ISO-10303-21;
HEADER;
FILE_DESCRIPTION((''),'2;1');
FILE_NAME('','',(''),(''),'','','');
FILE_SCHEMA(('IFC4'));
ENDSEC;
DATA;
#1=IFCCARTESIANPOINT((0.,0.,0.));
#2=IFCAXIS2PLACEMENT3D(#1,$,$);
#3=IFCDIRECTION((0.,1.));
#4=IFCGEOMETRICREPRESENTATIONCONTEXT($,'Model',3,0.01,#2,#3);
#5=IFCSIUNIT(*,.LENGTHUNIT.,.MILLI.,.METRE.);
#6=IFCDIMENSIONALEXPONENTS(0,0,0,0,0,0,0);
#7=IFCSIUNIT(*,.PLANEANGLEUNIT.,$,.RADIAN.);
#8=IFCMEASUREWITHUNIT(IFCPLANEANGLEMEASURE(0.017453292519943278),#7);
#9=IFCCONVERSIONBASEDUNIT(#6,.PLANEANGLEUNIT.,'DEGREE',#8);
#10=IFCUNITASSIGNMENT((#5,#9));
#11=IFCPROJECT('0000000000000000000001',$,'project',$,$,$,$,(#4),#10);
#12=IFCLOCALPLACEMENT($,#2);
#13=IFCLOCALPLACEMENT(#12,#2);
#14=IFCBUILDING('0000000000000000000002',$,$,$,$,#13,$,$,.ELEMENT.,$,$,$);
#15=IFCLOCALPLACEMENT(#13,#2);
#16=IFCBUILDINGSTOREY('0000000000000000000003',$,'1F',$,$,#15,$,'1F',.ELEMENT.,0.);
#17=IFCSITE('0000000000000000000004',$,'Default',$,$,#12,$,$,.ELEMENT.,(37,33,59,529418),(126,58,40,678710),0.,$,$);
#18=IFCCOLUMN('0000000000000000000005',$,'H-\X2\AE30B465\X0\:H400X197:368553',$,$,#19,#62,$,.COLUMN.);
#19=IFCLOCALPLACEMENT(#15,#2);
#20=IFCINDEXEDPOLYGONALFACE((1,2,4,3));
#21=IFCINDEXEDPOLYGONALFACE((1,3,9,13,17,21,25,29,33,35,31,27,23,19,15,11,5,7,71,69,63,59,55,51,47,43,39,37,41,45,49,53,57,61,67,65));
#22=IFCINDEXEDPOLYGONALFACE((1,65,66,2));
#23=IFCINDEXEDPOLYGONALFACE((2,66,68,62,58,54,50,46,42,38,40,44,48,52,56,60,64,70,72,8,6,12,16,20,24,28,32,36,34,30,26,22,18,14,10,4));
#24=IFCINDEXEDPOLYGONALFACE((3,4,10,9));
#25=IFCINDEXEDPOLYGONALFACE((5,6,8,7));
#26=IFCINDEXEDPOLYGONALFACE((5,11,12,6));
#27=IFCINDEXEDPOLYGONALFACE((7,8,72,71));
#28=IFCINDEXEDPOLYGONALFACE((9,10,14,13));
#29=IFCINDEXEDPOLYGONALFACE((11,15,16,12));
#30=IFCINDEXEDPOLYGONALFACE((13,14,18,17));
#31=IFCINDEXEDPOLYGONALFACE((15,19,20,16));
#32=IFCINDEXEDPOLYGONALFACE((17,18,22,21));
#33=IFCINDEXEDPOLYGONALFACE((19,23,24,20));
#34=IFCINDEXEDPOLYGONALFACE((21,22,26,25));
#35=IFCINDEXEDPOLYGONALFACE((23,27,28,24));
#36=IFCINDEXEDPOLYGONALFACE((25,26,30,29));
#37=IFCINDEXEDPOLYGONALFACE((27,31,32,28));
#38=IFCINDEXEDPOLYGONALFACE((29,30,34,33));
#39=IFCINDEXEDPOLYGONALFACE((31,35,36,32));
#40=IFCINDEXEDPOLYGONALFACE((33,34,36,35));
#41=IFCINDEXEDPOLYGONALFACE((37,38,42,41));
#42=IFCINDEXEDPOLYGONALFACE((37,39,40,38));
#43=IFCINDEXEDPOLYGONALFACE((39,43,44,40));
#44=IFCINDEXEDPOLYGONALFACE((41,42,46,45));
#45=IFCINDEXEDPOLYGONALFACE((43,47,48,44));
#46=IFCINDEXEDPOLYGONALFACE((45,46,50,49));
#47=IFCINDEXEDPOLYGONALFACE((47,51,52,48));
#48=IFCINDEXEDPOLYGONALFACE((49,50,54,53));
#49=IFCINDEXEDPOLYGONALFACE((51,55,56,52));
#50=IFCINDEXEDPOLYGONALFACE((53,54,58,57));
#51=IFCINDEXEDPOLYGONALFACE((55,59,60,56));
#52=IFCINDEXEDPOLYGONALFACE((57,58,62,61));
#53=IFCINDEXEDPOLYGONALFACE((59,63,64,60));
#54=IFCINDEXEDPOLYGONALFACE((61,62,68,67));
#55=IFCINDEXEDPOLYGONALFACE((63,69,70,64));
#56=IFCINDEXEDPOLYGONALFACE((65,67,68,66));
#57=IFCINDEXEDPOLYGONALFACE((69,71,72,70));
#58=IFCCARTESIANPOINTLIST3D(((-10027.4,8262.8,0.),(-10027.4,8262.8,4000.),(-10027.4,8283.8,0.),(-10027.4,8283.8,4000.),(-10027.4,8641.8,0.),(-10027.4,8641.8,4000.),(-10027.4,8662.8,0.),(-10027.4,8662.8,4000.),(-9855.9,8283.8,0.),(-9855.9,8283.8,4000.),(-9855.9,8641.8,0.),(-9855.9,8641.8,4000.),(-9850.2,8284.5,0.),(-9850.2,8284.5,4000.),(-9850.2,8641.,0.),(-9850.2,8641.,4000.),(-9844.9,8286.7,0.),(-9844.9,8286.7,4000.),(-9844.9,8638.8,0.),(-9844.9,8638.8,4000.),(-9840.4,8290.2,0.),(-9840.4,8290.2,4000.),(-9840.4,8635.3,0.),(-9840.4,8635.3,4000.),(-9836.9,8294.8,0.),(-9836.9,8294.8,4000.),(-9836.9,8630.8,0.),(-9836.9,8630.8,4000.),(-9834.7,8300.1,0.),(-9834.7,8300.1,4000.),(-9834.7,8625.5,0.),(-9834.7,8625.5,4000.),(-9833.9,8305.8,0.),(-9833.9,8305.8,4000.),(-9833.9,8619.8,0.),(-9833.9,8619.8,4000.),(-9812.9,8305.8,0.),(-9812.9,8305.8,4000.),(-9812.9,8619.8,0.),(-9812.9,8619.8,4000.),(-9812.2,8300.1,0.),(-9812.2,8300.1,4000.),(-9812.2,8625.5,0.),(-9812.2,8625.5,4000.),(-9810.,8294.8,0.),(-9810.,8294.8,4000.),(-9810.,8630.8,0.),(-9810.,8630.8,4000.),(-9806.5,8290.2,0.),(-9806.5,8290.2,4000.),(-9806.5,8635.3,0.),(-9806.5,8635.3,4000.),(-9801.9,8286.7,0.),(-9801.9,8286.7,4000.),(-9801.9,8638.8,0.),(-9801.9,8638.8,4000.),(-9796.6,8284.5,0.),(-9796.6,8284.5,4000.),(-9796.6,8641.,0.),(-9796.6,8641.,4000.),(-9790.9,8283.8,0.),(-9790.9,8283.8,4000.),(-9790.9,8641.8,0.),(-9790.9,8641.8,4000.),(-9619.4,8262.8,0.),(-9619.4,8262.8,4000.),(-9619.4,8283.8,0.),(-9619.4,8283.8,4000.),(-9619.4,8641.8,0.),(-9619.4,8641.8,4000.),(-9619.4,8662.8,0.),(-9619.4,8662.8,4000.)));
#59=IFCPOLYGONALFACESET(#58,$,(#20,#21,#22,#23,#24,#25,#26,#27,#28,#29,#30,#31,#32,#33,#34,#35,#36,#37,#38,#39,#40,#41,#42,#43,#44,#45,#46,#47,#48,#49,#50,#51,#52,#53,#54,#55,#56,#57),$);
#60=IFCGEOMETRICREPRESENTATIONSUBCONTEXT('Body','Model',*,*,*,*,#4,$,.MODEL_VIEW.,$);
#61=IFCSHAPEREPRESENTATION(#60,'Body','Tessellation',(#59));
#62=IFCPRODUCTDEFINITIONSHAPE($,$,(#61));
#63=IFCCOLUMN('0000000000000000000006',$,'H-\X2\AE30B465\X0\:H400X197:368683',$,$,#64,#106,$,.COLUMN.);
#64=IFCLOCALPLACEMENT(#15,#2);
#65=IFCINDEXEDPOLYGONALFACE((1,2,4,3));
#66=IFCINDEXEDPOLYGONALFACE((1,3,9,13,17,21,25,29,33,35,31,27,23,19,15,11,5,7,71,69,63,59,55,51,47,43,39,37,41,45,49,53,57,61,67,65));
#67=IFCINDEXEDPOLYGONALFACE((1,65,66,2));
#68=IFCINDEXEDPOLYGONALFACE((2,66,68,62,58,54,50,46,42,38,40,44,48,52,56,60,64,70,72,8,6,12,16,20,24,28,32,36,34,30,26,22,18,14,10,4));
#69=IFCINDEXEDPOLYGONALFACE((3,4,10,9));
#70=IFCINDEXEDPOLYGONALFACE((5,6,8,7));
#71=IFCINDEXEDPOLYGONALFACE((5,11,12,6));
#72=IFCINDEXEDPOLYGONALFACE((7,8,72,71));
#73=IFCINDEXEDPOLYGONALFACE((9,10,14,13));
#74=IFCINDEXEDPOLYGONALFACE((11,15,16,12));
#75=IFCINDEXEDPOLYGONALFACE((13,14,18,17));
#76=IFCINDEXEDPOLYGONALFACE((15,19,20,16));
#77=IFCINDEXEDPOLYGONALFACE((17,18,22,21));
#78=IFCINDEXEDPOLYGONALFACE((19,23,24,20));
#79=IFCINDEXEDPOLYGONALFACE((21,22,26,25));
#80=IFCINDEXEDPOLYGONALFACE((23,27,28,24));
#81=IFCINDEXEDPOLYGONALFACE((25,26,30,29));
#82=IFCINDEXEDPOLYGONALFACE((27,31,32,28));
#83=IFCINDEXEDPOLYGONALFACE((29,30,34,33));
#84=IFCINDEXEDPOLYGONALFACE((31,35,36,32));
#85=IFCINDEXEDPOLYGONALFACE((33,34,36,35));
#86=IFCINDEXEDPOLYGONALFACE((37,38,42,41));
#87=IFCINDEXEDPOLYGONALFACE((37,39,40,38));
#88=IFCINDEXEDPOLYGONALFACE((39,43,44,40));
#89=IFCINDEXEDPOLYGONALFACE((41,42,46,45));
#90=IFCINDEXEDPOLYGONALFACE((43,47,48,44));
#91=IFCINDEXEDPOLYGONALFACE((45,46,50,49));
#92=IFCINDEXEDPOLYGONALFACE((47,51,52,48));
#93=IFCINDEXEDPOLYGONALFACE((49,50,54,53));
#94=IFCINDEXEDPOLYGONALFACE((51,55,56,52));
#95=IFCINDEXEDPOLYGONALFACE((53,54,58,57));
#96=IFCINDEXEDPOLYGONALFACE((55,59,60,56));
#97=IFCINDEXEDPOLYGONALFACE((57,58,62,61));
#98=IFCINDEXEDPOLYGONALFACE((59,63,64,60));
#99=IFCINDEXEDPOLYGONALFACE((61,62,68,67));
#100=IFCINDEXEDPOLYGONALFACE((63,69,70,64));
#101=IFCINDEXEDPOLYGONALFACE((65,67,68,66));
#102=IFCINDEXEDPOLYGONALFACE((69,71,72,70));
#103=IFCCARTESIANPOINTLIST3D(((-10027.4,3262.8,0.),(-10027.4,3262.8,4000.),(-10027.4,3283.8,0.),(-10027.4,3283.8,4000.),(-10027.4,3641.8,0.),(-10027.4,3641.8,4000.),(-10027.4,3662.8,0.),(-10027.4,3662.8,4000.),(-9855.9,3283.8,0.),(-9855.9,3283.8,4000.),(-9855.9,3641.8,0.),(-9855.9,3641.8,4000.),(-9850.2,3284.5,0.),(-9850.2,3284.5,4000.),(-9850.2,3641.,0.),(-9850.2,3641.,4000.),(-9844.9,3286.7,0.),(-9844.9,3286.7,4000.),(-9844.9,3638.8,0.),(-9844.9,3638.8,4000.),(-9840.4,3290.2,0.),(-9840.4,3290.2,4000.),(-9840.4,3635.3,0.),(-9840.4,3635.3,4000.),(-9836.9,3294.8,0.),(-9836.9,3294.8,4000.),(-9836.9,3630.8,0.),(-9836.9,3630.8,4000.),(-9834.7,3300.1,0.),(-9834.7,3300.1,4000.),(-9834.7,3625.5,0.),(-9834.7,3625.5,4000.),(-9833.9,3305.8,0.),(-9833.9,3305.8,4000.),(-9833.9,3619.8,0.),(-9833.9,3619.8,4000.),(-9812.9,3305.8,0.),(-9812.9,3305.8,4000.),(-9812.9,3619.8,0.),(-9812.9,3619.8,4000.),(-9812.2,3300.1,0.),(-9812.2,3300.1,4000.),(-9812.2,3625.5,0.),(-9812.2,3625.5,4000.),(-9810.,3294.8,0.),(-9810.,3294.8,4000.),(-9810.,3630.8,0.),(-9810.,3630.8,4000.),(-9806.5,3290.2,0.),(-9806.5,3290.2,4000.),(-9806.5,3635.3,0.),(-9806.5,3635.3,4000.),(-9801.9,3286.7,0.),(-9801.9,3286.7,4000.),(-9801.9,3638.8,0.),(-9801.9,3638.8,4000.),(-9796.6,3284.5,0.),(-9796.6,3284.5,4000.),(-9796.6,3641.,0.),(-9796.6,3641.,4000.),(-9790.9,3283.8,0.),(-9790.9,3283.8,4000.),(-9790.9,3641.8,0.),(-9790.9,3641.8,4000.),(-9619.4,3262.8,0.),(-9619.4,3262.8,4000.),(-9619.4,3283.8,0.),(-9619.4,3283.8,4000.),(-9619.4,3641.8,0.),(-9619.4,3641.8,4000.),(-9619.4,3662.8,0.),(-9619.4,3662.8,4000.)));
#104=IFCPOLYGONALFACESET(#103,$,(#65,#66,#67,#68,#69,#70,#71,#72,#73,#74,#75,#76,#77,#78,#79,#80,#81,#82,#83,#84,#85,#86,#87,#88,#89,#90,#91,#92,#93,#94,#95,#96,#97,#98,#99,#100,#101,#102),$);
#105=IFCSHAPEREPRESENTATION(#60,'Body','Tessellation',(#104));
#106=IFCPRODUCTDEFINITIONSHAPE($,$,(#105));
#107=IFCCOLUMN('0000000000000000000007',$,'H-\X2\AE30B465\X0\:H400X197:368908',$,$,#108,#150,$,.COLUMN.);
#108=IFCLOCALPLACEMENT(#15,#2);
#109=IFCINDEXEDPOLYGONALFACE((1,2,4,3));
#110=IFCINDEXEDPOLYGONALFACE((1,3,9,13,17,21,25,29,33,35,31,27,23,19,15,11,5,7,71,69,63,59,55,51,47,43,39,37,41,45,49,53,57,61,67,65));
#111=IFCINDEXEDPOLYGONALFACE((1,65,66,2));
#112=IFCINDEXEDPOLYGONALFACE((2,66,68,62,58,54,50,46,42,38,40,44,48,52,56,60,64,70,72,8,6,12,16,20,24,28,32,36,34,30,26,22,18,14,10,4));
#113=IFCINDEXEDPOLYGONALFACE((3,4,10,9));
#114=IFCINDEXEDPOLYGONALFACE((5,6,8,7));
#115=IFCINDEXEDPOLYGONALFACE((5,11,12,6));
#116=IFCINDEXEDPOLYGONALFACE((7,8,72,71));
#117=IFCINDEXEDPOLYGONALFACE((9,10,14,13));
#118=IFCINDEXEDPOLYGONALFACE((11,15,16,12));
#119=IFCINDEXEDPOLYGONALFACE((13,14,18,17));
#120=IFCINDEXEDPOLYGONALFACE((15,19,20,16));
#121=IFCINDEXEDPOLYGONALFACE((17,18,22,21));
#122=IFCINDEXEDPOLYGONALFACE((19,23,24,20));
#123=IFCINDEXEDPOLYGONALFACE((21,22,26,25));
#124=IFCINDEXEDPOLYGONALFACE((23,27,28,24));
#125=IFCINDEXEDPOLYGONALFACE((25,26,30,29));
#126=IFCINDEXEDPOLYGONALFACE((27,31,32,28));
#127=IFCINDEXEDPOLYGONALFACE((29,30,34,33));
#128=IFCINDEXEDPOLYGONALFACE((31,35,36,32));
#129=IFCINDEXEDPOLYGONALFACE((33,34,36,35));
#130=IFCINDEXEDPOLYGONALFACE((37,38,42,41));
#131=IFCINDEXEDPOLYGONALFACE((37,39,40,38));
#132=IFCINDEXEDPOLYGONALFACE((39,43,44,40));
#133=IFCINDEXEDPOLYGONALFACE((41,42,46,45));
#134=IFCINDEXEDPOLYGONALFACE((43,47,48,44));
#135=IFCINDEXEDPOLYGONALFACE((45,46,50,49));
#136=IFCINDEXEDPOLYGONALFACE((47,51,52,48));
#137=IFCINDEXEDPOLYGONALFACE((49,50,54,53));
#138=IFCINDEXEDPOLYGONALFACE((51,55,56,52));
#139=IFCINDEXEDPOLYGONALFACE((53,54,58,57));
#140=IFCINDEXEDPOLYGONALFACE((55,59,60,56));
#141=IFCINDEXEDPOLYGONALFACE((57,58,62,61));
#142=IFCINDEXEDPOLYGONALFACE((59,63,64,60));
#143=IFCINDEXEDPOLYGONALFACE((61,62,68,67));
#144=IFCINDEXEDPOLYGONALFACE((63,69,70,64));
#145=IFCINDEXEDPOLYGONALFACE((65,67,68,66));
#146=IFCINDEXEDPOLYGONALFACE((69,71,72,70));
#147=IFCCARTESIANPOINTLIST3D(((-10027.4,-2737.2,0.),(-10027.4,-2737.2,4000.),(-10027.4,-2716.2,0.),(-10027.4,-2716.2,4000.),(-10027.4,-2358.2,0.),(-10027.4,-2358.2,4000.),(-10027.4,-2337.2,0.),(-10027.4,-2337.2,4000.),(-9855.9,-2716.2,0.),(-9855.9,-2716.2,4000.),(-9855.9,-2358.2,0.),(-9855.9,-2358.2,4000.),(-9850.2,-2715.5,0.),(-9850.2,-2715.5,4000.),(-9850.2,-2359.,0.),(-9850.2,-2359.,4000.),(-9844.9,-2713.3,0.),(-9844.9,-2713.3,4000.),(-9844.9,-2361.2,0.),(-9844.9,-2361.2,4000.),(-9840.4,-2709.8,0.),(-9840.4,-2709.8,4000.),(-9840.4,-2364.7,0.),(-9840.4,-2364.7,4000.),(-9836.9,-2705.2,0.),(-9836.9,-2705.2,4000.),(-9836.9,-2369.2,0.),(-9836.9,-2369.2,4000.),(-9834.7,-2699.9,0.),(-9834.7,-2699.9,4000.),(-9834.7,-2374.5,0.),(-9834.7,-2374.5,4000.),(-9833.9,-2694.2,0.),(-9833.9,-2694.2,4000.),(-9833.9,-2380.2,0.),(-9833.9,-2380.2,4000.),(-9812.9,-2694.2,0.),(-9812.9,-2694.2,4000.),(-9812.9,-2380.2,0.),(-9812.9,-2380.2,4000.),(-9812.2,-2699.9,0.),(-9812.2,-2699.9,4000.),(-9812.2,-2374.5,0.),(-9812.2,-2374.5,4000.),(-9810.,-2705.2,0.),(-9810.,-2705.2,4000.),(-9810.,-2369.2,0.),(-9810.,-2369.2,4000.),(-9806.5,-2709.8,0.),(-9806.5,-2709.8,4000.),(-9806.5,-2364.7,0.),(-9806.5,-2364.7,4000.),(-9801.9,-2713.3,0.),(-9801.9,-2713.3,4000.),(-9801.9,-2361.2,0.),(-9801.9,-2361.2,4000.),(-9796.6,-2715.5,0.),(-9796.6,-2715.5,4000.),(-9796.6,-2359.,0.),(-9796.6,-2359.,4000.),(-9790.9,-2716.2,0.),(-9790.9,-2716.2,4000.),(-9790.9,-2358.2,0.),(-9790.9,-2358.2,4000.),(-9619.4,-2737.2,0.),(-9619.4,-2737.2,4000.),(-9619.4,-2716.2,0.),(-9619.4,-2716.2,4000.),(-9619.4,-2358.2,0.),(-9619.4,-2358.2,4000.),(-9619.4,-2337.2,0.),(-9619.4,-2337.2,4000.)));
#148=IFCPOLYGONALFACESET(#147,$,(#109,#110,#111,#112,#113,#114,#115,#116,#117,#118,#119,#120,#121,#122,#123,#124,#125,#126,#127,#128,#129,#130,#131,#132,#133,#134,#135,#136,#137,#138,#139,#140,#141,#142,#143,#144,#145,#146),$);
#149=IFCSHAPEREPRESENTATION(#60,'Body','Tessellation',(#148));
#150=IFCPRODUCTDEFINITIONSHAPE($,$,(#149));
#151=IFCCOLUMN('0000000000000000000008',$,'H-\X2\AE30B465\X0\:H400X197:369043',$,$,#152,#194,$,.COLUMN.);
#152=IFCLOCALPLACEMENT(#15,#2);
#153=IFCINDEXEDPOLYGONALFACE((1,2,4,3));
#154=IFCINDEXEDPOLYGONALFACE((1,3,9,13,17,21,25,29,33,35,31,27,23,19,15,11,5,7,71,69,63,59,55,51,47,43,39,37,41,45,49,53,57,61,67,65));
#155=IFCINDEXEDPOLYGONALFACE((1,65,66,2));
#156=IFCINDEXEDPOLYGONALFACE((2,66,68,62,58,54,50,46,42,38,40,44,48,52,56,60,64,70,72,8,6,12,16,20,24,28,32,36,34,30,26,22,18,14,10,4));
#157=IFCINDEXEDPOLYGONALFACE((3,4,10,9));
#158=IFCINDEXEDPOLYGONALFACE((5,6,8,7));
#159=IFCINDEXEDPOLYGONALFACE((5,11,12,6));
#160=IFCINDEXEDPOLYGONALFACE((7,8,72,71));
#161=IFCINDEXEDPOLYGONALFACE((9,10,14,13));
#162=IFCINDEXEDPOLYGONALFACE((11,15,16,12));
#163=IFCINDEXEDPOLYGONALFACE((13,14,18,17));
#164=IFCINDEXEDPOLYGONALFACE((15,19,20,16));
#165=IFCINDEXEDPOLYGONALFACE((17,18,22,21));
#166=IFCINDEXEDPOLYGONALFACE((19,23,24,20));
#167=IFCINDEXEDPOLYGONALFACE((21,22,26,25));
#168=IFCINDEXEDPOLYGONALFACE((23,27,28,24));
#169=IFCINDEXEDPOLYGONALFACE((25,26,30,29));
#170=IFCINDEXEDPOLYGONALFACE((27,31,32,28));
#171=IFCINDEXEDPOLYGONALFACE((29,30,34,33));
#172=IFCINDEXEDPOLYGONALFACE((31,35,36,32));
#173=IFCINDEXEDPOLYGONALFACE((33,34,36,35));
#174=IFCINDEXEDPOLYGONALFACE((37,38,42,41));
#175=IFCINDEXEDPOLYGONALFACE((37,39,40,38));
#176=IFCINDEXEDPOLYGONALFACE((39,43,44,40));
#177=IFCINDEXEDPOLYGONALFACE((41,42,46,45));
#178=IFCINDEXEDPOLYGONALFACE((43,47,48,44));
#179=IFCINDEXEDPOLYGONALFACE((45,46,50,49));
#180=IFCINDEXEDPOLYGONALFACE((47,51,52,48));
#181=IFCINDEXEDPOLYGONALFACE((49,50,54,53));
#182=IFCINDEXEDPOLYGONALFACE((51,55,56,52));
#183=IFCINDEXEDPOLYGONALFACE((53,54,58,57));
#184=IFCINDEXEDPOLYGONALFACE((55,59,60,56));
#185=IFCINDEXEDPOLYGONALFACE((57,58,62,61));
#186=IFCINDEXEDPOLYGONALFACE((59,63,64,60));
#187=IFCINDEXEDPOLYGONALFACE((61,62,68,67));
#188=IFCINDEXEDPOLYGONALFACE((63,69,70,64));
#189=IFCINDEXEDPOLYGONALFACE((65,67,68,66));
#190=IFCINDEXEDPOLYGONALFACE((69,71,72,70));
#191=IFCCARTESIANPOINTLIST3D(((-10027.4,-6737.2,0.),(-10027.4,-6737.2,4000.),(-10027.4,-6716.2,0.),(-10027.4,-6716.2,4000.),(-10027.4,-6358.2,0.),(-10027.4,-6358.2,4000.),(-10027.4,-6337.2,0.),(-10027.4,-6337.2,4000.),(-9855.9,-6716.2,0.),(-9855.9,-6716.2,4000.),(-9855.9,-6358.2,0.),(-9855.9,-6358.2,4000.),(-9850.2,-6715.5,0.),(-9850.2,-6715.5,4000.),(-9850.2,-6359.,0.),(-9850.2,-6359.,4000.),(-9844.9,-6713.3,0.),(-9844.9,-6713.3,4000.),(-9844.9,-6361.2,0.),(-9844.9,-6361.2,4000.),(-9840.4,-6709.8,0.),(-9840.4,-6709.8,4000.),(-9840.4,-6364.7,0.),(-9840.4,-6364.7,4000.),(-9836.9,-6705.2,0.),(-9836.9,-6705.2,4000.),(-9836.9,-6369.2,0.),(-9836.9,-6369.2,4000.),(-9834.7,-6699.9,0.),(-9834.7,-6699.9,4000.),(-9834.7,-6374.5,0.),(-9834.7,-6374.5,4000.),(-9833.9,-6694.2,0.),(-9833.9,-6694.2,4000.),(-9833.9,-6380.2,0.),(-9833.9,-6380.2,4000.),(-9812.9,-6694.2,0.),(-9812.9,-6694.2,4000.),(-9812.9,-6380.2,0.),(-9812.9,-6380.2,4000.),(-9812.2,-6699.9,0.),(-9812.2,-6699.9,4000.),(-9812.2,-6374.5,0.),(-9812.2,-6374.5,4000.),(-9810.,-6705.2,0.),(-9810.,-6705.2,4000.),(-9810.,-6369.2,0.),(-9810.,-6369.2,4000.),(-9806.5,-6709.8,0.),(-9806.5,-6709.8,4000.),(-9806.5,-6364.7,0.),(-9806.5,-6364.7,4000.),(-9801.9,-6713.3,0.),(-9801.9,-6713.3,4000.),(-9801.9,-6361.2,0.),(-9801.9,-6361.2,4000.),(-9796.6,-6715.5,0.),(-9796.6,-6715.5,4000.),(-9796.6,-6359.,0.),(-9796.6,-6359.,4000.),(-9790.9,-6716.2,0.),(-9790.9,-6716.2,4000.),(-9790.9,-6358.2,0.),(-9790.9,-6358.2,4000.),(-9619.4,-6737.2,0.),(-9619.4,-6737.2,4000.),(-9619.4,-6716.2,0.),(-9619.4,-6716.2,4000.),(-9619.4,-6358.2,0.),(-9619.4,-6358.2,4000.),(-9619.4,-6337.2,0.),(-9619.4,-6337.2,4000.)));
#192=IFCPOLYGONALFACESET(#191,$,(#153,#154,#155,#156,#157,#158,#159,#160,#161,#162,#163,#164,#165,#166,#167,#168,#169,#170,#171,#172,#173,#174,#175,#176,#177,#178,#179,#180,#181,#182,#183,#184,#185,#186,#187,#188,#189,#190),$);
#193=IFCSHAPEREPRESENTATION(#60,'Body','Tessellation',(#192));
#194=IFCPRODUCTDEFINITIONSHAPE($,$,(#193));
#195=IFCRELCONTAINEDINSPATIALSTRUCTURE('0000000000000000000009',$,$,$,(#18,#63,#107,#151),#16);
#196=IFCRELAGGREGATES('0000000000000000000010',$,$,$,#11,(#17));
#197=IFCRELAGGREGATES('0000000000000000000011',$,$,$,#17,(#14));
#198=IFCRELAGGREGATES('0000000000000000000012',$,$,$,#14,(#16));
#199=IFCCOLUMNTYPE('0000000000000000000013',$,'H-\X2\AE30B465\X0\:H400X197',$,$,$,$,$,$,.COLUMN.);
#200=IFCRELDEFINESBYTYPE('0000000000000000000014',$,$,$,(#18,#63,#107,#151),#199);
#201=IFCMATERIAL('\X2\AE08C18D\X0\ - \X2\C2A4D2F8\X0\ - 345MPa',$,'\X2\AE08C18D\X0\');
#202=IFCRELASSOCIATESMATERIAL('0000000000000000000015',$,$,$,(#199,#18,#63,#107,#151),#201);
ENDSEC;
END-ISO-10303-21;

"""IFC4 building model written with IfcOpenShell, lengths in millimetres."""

from ifc_helpers import new_model, entity, si_unit, converted_unit, direction, frame, origin, place, context, subcontext, project, spatial, line, arc, indexed_curve, outline, extrude, source, transform, mapped, material, type_object, type_shapes, element, save


model = new_model("IFC4")

# Units and contexts
model_context = context("Model", 3, precision=0.01, world=origin(), true_north=direction((0.0, 1.0)))
body_context = subcontext(model_context, "Body", "Model", "MODEL_VIEW")
ifc_project = project(units=[si_unit("LENGTHUNIT", "METRE", prefix="MILLI"), converted_unit("PLANEANGLEUNIT", "DEGREE", entity("IfcPlaneAngleMeasure", 0.017453292519943278), si_unit("PLANEANGLEUNIT", "RADIAN"), dimensions=[0, 0, 0, 0, 0, 0, 0])], contexts=[model_context])

# Site, building, storey
site_placement = place(None, origin())
site = spatial("IfcSite", under=ifc_project, at=site_placement, Name="Default", CompositionType="ELEMENT", RefLatitude=(37, 33, 59, 529418), RefLongitude=(126, 58, 40, 678710), RefElevation=0.0)
building_placement = place(site_placement, origin())
building = spatial("IfcBuilding", under=site, at=building_placement, CompositionType="ELEMENT")
storey_placement = place(building_placement, origin())
storey = spatial("IfcBuildingStorey", under=building, at=storey_placement, Name="1F", LongName="1F", CompositionType="ELEMENT", Elevation=0.0)

# Columns
ifc_material = material(Name="금속 - 스틸 - 345MPa", Category="금속")
column_type = type_object("IfcColumnType", Name="H-기둥:H400X197", PredefinedType="COLUMN", material=ifc_material)
shared_shape = source(origin(), body_context, "Body", "SweptSolid", [
    extrude(outline(indexed_curve([(-204.0, -200.0), (204.0, -200.0), (204.0, -179.0), (32.5, -179.0), (16.9, -172.6), (10.5, -157.0), (10.5, 157.0), (16.9, 172.6), (32.5, 179.0), (204.0, 179.0), (204.0, 200.0), (-204.0, 200.0), (-204.0, 179.0), (-32.5, 179.0), (-16.9, 172.6), (-10.5, 157.0), (-10.5, -157.0), (-16.9, -172.6), (-32.5, -179.0), (-204.0, -179.0)], segments=[line(1, 2, 3, 4), arc(4, 5, 6), line(6, 7), arc(7, 8, 9), line(9, 10, 11, 12, 13, 14), arc(14, 15, 16), line(16, 17), arc(17, 18, 19), line(19, 20, 1)], self_intersect=False)), frame((0.0, 0.0, 0.0), z_axis=(0.0, 0.0, 1.0), x_axis=(-1.0, 0.0, 0.0)), (0.0, 0.0, 1.0), 4000.0),
])
type_shapes(column_type, [shared_shape])
for number, where, name in (
    (1, (-9823.4, 8462.8, 0.0), "H-기둥:H400X197:368553"),
    (2, (-9823.4, 3462.8, 0.0), "H-기둥:H400X197:368683"),
    (3, (-9823.4, -2537.2, 0.0), "H-기둥:H400X197:368908"),
    (4, (-9823.4, -6537.2, 0.0), "H-기둥:H400X197:369043"),
):
    element("IfcColumn", number, at=place(storey_placement, frame(where)), inside=storey, type_object=column_type, material=ifc_material, Name=name, PredefinedType="COLUMN", context=body_context, shape_type="MappedRepresentation", body=[
        mapped(shared_shape, transform((0.0, 0.0, 0.0), scale=1.0)),
    ])

save(model, "model.ifc")
